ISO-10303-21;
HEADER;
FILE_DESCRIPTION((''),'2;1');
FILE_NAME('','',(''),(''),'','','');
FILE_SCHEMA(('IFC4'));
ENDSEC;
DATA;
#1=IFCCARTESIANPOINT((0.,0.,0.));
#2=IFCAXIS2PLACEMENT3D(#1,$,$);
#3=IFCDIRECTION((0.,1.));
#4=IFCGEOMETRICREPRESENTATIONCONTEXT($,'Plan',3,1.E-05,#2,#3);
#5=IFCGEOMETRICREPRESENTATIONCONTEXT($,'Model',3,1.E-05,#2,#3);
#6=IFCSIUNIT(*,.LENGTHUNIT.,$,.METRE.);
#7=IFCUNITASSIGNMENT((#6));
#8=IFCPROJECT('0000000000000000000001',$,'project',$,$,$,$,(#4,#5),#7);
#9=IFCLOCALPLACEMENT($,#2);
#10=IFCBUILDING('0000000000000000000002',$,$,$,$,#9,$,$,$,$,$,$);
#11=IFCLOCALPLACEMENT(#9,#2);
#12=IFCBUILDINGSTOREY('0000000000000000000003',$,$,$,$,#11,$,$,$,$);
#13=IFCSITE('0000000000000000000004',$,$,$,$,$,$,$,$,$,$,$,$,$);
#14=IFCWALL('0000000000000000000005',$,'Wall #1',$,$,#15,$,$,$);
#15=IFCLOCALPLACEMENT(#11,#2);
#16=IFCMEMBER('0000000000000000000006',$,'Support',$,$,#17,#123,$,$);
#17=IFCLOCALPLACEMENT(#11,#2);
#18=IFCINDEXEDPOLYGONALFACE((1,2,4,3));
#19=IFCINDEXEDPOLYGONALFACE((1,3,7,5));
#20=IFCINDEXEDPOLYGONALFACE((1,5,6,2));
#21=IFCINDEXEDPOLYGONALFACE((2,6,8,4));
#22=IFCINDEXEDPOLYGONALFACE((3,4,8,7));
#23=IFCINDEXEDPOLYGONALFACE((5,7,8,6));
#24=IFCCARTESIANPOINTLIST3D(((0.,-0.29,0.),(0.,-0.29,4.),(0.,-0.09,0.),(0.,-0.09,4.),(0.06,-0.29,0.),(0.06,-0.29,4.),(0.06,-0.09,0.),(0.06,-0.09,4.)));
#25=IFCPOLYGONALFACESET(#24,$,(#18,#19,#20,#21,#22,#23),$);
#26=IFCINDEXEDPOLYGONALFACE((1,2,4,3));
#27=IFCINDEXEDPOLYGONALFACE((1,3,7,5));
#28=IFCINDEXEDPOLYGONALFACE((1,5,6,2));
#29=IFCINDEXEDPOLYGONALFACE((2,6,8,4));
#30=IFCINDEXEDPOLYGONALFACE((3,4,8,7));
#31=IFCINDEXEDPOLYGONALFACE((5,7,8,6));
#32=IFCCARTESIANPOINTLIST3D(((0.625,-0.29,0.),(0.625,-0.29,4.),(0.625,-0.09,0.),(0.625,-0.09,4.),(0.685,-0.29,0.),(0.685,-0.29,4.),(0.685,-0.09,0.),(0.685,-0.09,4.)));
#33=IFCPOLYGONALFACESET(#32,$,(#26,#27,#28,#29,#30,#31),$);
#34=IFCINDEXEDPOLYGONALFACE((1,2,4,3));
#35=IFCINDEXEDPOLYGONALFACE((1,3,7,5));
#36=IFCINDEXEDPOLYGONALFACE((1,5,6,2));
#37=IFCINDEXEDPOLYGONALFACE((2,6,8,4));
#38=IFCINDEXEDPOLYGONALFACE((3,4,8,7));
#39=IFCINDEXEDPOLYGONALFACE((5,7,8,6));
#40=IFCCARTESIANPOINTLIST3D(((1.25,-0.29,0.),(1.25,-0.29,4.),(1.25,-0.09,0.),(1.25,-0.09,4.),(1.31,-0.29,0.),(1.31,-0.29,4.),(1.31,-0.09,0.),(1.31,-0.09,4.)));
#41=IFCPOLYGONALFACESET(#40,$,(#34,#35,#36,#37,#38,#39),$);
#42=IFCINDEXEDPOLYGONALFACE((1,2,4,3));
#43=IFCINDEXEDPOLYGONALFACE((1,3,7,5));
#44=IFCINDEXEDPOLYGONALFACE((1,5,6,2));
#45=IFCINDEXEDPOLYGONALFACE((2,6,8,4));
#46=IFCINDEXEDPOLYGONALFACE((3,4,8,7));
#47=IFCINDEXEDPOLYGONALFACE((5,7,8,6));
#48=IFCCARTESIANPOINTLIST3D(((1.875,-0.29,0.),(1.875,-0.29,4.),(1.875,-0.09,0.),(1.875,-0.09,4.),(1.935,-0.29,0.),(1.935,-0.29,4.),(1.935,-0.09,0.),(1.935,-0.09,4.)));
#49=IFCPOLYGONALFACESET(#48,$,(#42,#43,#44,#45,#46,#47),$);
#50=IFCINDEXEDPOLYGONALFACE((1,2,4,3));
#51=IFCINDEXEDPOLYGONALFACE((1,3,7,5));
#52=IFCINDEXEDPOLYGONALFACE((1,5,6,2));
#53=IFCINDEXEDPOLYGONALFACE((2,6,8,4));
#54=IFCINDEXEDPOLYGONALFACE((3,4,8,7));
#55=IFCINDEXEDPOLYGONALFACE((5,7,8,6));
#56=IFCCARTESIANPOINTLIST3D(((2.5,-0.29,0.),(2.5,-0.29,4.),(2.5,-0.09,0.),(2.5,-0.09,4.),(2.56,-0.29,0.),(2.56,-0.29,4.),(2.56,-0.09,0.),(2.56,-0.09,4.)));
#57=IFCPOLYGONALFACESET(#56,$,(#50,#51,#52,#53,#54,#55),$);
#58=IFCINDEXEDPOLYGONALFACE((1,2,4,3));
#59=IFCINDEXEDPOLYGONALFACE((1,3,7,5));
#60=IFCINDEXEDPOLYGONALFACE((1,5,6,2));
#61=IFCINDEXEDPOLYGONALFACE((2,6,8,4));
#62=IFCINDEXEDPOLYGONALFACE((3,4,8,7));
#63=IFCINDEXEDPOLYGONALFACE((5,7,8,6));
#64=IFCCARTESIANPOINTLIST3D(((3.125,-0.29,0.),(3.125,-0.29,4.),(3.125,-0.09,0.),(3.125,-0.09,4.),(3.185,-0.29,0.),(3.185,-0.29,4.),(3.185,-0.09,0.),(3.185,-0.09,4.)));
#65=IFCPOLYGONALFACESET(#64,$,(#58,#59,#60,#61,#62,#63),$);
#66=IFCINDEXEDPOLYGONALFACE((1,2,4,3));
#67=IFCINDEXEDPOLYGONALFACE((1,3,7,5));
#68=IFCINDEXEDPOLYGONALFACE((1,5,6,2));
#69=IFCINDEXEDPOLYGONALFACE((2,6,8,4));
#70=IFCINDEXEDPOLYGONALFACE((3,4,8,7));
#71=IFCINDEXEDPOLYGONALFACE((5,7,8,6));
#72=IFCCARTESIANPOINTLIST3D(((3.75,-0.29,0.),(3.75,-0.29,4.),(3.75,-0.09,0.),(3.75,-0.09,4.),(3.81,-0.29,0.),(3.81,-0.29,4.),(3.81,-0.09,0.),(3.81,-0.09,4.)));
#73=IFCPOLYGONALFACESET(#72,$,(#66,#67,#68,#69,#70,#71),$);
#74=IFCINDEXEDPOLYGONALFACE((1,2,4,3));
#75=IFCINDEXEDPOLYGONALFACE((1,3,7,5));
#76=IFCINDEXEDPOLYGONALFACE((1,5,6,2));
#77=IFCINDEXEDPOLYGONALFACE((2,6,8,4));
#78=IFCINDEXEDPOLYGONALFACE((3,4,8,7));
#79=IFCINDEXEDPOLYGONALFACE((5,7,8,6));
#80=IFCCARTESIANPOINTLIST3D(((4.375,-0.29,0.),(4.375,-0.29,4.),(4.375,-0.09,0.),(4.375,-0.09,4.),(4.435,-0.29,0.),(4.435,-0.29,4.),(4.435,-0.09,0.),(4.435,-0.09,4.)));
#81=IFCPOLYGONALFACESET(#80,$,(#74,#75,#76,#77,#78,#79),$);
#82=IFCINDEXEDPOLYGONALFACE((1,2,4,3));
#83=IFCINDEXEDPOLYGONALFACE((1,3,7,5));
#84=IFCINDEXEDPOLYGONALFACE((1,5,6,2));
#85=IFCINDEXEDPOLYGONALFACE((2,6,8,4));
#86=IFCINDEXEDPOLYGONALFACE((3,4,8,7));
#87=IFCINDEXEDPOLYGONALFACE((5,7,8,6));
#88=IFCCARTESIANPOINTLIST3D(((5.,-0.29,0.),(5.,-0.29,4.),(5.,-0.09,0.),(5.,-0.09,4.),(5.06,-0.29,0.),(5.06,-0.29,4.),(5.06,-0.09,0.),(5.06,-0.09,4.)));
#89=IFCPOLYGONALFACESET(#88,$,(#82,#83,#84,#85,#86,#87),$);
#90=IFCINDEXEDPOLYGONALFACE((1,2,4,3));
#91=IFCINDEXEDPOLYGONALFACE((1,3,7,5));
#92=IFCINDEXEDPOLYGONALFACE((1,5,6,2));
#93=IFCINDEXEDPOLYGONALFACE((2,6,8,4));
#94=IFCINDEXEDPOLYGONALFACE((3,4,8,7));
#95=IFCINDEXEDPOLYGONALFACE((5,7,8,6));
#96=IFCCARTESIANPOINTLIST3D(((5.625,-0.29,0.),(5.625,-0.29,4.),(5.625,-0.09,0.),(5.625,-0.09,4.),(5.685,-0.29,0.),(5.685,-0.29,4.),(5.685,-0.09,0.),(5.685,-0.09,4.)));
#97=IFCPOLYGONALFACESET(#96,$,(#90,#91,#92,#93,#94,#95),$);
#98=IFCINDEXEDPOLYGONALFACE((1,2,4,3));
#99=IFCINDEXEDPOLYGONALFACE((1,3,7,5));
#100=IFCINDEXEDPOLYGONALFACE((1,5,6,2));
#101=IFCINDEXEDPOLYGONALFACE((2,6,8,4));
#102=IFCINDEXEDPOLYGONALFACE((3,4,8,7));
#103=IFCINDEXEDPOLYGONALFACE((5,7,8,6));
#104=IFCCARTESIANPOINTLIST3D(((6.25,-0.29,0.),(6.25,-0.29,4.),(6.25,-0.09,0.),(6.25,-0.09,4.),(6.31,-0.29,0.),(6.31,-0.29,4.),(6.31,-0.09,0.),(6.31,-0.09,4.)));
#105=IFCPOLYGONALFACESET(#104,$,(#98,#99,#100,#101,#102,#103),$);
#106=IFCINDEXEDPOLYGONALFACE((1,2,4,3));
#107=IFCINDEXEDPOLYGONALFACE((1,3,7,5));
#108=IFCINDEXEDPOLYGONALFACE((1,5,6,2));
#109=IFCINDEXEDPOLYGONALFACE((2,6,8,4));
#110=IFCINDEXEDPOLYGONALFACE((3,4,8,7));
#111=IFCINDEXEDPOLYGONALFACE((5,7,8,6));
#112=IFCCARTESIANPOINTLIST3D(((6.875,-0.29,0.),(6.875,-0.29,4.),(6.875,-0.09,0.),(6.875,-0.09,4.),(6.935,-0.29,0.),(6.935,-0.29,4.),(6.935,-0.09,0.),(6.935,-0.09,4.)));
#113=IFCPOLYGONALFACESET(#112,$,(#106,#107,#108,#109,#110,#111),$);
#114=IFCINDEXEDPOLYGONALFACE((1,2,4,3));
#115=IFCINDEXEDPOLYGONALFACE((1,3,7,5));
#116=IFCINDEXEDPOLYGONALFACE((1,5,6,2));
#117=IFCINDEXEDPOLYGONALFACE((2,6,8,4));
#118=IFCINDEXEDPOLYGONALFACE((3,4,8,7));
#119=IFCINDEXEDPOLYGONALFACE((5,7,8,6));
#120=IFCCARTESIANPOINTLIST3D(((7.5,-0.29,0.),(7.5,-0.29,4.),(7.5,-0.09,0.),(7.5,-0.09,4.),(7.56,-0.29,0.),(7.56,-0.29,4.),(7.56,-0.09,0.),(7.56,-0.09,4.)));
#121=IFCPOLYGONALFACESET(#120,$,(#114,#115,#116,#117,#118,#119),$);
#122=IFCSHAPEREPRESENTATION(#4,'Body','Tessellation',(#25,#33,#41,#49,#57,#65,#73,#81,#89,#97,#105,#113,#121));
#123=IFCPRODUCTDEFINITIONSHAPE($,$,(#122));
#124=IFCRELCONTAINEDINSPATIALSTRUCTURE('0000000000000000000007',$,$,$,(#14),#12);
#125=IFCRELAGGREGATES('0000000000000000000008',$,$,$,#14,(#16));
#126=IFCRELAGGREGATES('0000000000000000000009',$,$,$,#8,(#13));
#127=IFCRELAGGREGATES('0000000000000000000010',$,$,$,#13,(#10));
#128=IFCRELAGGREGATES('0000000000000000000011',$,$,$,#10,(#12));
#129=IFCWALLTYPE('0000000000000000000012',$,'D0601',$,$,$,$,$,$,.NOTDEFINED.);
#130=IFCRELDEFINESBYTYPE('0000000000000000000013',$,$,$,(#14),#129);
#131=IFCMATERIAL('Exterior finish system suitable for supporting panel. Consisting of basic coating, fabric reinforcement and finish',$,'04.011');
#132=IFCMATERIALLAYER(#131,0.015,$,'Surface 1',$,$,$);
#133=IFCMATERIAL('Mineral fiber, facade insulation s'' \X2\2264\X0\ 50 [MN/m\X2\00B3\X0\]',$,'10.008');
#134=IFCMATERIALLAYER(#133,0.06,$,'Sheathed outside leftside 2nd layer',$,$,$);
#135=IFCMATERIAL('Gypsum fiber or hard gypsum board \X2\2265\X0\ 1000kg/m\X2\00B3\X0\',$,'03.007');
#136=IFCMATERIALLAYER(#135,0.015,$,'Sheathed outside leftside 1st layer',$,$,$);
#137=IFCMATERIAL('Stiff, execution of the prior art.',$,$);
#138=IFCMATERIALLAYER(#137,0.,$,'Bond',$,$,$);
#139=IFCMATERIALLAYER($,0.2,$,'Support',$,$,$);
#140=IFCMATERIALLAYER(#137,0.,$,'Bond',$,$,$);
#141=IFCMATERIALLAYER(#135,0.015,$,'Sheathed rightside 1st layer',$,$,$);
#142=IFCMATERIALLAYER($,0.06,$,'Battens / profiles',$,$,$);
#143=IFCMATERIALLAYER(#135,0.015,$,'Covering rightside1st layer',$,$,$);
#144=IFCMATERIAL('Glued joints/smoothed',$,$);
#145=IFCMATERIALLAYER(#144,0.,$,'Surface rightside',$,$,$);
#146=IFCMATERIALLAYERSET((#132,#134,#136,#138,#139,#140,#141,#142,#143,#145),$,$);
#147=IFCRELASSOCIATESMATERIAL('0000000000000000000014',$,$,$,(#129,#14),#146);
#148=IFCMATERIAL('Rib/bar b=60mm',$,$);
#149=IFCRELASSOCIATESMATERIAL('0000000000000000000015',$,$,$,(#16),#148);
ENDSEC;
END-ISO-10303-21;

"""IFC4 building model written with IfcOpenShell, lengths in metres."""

from ifc_helpers import new_model, si_unit, direction, frame, frame_2d, origin, place, context, project, spatial, rectangle, extrude, material, layer, layer_set, type_object, element, aggregate, save


model = new_model("IFC4")

# Units and contexts
plan_context = context("Plan", 3, precision=1e-05, world=origin(), true_north=direction((0.0, 1.0)))
model_context = context("Model", 3, precision=1e-05, world=origin(), true_north=direction((0.0, 1.0)))
ifc_project = project(units=[si_unit("LENGTHUNIT", "METRE")], contexts=[plan_context, model_context])

# Site, building, storey
site = spatial("IfcSite", under=ifc_project)
building_placement = place(None, origin())
building = spatial("IfcBuilding", under=site, at=building_placement)
storey_placement = place(building_placement, origin())
storey = spatial("IfcBuildingStorey", under=building, at=storey_placement)

# Wall, member
ifc_material_1 = material(Name="Exterior finish system suitable for supporting panel. Consisting of basic coating, fabric reinforcement and finish", Category="04.011")
ifc_layer_1 = layer(ifc_material_1, 0.015, Name="Surface 1")
ifc_material_2 = material(Name="Mineral fiber, facade insulation s' ≤ 50 [MN/m³]", Category="10.008")
ifc_layer_2 = layer(ifc_material_2, 0.06, Name="Sheathed outside leftside 2nd layer")
ifc_material_3 = material(Name="Gypsum fiber or hard gypsum board ≥ 1000kg/m³", Category="03.007")
ifc_layer_3 = layer(ifc_material_3, 0.015, Name="Sheathed outside leftside 1st layer")
ifc_material_4 = material(Name="Stiff, execution of the prior art.")
ifc_layer_4 = layer(ifc_material_4, 0.0, Name="Bond")
ifc_layer_5 = layer(None, 0.2, Name="Support")
ifc_layer_6 = layer(ifc_material_4, 0.0, Name="Bond")
ifc_layer_7 = layer(ifc_material_3, 0.015, Name="Sheathed rightside 1st layer")
ifc_layer_8 = layer(None, 0.06, Name="Battens / profiles")
ifc_layer_9 = layer(ifc_material_3, 0.015, Name="Covering rightside1st layer")
ifc_material_5 = material(Name="Glued joints/smoothed")
ifc_layer_10 = layer(ifc_material_5, 0.0, Name="Surface rightside")
ifc_layer_set = layer_set([ifc_layer_1, ifc_layer_2, ifc_layer_3, ifc_layer_4, ifc_layer_5, ifc_layer_6, ifc_layer_7, ifc_layer_8, ifc_layer_9, ifc_layer_10])
wall_type = type_object("IfcWallType", Name="D0601", PredefinedType="NOTDEFINED", material=ifc_layer_set)
wall_placement = place(None, frame((0.0, 0.0, 0.0), z_axis=(0.0, -1.0, 0.0), x_axis=(1.0, 0.0, 0.0)))
wall = element("IfcWall", 1, at=wall_placement, inside=storey, type_object=wall_type, material=ifc_layer_set, Name="Wall #1")
ifc_material_6 = material(Name="Rib/bar b=60mm")
member_1_placement = place(wall_placement, origin())
member_1 = element("IfcMember", 2, at=member_1_placement, material=ifc_material_6, Name="Support", context=plan_context, shape_type="SweptSolid", body=[
    extrude(rectangle(XDim=0.06, YDim=0.2, at=frame_2d((0.03, 0.1), x_axis=(1.0, 0.0))), frame((0.0, 4.0, 0.09), z_axis=(0.0, -1.0, 0.0), x_axis=(1.0, 0.0, 0.0)), (0.0, 0.0, 1.0), 4.0),
    extrude(rectangle(XDim=0.06, YDim=0.2, at=frame_2d((0.03, 0.1), x_axis=(1.0, 0.0))), frame((0.625, 4.0, 0.09), z_axis=(0.0, -1.0, 0.0), x_axis=(1.0, 0.0, 0.0)), (0.0, 0.0, 1.0), 4.0),
    extrude(rectangle(XDim=0.06, YDim=0.2, at=frame_2d((0.03, 0.1), x_axis=(1.0, 0.0))), frame((1.25, 4.0, 0.09), z_axis=(0.0, -1.0, 0.0), x_axis=(1.0, 0.0, 0.0)), (0.0, 0.0, 1.0), 4.0),
    extrude(rectangle(XDim=0.06, YDim=0.2, at=frame_2d((0.03, 0.1), x_axis=(1.0, 0.0))), frame((1.875, 4.0, 0.09), z_axis=(0.0, -1.0, 0.0), x_axis=(1.0, 0.0, 0.0)), (0.0, 0.0, 1.0), 4.0),
    extrude(rectangle(XDim=0.06, YDim=0.2, at=frame_2d((0.03, 0.1), x_axis=(1.0, 0.0))), frame((2.5, 4.0, 0.09), z_axis=(0.0, -1.0, 0.0), x_axis=(1.0, 0.0, 0.0)), (0.0, 0.0, 1.0), 4.0),
    extrude(rectangle(XDim=0.06, YDim=0.2, at=frame_2d((0.03, 0.1), x_axis=(1.0, 0.0))), frame((3.125, 4.0, 0.09), z_axis=(0.0, -1.0, 0.0), x_axis=(1.0, 0.0, 0.0)), (0.0, 0.0, 1.0), 4.0),
    extrude(rectangle(XDim=0.06, YDim=0.2, at=frame_2d((0.03, 0.1), x_axis=(1.0, 0.0))), frame((3.75, 4.0, 0.09), z_axis=(0.0, -1.0, 0.0), x_axis=(1.0, 0.0, 0.0)), (0.0, 0.0, 1.0), 4.0),
    extrude(rectangle(XDim=0.06, YDim=0.2, at=frame_2d((0.03, 0.1), x_axis=(1.0, 0.0))), frame((4.375, 4.0, 0.09), z_axis=(0.0, -1.0, 0.0), x_axis=(1.0, 0.0, 0.0)), (0.0, 0.0, 1.0), 4.0),
    extrude(rectangle(XDim=0.06, YDim=0.2, at=frame_2d((0.03, 0.1), x_axis=(1.0, 0.0))), frame((5.0, 4.0, 0.09), z_axis=(0.0, -1.0, 0.0), x_axis=(1.0, 0.0, 0.0)), (0.0, 0.0, 1.0), 4.0),
    extrude(rectangle(XDim=0.06, YDim=0.2, at=frame_2d((0.03, 0.1), x_axis=(1.0, 0.0))), frame((5.625, 4.0, 0.09), z_axis=(0.0, -1.0, 0.0), x_axis=(1.0, 0.0, 0.0)), (0.0, 0.0, 1.0), 4.0),
    extrude(rectangle(XDim=0.06, YDim=0.2, at=frame_2d((0.03, 0.1), x_axis=(1.0, 0.0))), frame((6.25, 4.0, 0.09), z_axis=(0.0, -1.0, 0.0), x_axis=(1.0, 0.0, 0.0)), (0.0, 0.0, 1.0), 4.0),
    extrude(rectangle(XDim=0.06, YDim=0.2, at=frame_2d((0.03, 0.1), x_axis=(1.0, 0.0))), frame((6.875, 4.0, 0.09), z_axis=(0.0, -1.0, 0.0), x_axis=(1.0, 0.0, 0.0)), (0.0, 0.0, 1.0), 4.0),
    extrude(rectangle(XDim=0.06, YDim=0.2, at=frame_2d((0.03, 0.1), x_axis=(1.0, 0.0))), frame((7.5, 4.0, 0.09), z_axis=(0.0, -1.0, 0.0), x_axis=(1.0, 0.0, 0.0)), (0.0, 0.0, 1.0), 4.0),
])
aggregate(wall, [member_1])

save(model, "model.ifc")
